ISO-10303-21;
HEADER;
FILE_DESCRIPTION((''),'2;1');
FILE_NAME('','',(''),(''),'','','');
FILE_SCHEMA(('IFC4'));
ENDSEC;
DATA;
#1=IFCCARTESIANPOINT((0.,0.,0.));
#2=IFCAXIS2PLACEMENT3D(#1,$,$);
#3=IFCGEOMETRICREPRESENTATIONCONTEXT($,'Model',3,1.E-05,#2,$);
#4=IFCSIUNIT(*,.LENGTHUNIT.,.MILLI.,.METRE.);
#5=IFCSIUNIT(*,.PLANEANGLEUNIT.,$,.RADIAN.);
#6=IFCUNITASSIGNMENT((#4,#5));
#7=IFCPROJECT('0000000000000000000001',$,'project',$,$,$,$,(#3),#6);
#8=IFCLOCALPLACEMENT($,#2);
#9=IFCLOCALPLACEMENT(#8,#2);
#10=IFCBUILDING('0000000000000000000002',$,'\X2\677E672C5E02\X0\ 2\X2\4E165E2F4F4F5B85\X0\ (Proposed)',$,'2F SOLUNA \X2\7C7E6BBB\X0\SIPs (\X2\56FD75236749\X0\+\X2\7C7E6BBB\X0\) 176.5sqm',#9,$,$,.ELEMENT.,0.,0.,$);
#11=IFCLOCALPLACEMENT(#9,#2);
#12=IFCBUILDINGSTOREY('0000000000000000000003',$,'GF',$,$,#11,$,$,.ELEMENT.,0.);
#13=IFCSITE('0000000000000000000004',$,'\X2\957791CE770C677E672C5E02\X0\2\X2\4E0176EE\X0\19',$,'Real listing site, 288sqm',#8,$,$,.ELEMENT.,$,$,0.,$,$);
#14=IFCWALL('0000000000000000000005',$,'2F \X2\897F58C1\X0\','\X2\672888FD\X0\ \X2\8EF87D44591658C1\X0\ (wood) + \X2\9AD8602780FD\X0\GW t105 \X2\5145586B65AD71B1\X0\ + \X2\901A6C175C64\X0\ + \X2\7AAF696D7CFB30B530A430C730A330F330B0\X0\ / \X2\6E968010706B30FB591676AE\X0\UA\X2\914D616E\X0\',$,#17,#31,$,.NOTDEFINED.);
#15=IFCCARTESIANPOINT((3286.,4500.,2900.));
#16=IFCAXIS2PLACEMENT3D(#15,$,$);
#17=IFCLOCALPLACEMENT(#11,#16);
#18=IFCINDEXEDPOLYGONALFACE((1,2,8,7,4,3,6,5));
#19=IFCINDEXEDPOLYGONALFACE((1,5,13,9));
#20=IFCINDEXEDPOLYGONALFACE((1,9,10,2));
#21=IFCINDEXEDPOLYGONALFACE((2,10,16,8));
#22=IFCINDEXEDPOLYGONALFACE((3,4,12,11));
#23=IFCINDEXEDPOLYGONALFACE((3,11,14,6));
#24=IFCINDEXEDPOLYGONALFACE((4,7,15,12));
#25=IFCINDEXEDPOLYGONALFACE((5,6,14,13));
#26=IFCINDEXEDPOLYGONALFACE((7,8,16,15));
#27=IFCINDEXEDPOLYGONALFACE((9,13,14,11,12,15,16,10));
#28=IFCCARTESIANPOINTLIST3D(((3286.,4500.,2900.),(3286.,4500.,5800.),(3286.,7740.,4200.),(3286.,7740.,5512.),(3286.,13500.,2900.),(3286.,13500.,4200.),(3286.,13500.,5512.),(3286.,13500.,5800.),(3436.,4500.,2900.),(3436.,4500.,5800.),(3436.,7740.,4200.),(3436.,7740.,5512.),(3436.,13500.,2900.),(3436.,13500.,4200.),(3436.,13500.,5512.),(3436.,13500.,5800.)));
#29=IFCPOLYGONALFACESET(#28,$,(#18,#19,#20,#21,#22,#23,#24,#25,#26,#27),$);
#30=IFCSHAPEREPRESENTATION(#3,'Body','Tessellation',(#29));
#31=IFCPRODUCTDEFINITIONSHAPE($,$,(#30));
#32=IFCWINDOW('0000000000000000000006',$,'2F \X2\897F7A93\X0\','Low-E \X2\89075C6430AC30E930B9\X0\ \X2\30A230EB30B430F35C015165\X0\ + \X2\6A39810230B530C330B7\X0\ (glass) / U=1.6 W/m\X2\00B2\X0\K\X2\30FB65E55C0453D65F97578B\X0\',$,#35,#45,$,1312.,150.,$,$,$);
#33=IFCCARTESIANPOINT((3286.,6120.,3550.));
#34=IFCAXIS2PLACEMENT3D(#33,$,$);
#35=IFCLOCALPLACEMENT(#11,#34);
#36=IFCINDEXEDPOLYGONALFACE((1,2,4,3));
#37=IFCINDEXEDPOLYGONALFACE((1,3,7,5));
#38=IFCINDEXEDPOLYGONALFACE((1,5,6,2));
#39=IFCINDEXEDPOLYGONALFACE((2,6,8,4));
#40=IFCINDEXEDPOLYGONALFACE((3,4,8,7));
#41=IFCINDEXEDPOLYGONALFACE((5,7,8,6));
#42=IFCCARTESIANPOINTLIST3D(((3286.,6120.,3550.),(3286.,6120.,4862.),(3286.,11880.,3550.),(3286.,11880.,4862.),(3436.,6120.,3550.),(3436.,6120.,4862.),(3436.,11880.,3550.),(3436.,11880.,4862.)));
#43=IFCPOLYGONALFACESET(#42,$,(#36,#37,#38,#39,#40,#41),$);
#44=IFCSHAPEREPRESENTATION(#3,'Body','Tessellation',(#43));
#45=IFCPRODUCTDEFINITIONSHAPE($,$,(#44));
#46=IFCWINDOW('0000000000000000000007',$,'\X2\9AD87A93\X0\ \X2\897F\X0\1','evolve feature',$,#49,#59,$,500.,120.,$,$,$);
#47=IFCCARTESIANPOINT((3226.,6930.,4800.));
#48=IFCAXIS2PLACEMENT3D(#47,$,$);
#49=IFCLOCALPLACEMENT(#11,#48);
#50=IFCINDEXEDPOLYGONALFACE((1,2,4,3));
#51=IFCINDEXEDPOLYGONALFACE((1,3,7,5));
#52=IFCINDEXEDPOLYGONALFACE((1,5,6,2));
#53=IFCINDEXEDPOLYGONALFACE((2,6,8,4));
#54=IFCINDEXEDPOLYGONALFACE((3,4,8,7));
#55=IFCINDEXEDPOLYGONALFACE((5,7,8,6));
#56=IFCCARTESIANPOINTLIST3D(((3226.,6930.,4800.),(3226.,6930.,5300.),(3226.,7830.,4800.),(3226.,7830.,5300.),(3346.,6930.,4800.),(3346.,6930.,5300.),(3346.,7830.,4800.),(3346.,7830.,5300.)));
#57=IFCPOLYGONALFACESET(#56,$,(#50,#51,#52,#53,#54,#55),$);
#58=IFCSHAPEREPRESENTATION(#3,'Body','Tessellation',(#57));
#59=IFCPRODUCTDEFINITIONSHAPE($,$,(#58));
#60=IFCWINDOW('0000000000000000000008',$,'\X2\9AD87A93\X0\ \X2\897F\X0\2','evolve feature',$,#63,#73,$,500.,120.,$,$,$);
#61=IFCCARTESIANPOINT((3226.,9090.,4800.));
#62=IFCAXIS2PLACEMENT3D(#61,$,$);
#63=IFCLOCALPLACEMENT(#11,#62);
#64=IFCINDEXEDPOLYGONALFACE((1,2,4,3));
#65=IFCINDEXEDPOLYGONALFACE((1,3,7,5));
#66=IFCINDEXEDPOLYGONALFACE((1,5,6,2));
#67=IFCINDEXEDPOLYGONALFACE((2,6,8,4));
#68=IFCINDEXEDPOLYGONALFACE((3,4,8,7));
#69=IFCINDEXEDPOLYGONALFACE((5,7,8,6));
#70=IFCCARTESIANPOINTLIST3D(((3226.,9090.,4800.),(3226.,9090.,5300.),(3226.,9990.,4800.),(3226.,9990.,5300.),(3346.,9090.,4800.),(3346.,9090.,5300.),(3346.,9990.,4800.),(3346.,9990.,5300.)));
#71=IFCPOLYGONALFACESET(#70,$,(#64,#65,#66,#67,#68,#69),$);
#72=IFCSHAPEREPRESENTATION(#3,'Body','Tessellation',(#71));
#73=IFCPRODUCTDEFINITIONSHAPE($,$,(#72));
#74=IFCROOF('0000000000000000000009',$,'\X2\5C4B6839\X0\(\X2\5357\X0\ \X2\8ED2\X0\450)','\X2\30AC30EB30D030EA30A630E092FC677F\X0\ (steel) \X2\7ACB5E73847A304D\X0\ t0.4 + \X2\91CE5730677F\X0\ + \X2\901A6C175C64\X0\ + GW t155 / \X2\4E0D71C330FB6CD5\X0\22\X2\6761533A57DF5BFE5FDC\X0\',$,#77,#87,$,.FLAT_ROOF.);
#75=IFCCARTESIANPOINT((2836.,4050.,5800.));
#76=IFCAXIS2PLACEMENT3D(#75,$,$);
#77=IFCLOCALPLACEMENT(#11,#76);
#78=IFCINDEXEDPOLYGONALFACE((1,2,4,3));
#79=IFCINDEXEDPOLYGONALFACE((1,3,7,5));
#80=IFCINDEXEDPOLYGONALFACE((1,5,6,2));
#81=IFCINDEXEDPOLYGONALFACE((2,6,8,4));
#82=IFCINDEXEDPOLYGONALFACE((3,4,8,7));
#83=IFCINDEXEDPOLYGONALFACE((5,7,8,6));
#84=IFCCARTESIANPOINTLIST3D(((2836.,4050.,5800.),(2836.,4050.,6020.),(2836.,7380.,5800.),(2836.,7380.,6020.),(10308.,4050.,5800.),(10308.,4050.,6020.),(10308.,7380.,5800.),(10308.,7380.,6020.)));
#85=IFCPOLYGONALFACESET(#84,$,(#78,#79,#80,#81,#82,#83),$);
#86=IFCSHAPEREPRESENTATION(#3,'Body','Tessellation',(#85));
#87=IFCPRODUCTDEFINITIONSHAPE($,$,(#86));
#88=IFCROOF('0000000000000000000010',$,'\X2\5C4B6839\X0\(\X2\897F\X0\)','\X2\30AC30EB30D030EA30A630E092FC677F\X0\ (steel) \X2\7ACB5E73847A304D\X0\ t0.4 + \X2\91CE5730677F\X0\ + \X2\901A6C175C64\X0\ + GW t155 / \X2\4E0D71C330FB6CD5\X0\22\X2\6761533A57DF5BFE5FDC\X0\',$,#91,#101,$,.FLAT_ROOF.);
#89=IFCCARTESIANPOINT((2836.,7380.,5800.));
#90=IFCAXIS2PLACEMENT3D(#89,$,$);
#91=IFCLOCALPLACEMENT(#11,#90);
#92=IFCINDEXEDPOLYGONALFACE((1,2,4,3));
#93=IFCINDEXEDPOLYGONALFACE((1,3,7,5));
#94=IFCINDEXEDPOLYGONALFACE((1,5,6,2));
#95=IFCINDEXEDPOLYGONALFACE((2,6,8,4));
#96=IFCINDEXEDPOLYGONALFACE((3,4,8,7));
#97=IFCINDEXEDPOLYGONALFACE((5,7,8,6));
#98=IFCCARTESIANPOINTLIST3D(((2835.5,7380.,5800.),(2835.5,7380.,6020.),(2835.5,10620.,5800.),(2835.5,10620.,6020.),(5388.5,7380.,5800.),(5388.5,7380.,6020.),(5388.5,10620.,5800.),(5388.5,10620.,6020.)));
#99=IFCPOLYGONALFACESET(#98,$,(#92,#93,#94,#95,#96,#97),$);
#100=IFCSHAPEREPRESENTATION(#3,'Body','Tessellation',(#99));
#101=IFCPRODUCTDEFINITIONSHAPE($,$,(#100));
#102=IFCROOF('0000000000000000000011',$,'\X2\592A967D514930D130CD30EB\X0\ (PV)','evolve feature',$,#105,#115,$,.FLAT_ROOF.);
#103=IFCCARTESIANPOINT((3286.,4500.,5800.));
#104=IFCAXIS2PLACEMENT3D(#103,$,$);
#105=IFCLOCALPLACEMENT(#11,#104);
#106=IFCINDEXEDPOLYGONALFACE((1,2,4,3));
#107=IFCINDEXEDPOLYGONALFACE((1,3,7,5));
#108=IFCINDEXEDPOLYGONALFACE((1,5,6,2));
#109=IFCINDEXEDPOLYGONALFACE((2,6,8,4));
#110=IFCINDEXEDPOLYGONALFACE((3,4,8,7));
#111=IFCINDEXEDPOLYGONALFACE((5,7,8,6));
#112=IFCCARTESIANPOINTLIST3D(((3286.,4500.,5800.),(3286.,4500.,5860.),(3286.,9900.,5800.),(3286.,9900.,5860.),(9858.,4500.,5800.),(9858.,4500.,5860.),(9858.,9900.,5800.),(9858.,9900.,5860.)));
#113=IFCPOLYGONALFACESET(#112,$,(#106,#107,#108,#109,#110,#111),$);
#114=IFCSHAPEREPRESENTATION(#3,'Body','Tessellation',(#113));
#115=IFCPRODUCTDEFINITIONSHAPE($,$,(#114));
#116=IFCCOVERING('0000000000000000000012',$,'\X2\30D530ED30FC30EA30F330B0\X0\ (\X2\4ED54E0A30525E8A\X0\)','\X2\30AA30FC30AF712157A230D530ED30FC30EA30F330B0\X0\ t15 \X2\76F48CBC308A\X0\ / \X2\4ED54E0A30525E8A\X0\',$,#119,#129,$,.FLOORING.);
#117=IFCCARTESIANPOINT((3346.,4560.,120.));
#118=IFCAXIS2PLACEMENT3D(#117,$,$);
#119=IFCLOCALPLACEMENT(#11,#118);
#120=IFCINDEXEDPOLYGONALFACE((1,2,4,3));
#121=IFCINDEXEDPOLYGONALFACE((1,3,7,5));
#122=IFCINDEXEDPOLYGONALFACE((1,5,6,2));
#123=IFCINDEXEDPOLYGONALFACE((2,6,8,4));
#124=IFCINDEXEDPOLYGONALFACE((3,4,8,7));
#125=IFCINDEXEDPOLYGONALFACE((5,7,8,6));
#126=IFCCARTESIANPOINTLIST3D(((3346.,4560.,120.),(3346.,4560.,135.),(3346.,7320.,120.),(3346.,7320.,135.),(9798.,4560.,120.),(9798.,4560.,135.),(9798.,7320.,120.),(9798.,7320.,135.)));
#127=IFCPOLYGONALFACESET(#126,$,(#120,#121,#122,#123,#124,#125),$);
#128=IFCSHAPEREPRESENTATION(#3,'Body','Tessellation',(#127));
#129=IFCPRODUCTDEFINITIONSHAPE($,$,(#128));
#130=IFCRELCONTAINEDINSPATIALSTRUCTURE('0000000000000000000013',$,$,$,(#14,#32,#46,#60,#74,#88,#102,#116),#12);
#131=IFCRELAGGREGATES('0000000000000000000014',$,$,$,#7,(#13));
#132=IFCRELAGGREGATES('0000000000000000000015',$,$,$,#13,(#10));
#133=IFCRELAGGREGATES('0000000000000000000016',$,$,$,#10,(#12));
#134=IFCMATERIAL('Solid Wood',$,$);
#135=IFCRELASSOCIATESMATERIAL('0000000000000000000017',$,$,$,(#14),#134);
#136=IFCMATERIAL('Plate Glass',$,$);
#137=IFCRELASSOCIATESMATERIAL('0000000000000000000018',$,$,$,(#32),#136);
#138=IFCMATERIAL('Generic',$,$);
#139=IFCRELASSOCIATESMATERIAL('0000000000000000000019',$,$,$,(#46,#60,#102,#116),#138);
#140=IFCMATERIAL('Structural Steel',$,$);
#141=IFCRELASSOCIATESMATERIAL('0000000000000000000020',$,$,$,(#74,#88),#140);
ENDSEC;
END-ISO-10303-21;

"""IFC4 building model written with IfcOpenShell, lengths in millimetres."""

from ifc_helpers import new_model, si_unit, frame, frame_2d, origin, place, context, project, spatial, rectangle, extrude, material, element, fill, save


model = new_model("IFC4")

# Units and contexts
model_context = context("Model", 3, precision=1e-05, world=origin())
ifc_project = project(units=[si_unit("LENGTHUNIT", "METRE", prefix="MILLI"), si_unit("PLANEANGLEUNIT", "RADIAN")], contexts=[model_context])

# Site, building, storey
site_placement = place(None, origin())
site = spatial("IfcSite", under=ifc_project, at=site_placement, Name="長野県松本市2丁目19", ObjectType="Real listing site, 288sqm", CompositionType="ELEMENT", RefElevation=0.0)
building_placement = place(site_placement, origin())
building = spatial("IfcBuilding", under=site, at=building_placement, Name="松本市 2世帯住宅 (Proposed)", ObjectType="2F SOLUNA 籾殻SIPs (国産杉+籾殻) 176.5sqm", CompositionType="ELEMENT", ElevationOfRefHeight=0.0, ElevationOfTerrain=0.0)
storey_placement = place(building_placement, origin())
storey = spatial("IfcBuildingStorey", under=building, at=storey_placement, Name="GF", CompositionType="ELEMENT", Elevation=0.0)

# Shared definitions
ifc_material_1 = material(Name="Solid Wood")
ifc_material_2 = material(Name="Generic")

# Shared definitions
ifc_material_3 = material(Name="Plate Glass")

# Wall, openings, windows
wall_1_placement = place(storey_placement, frame((3286.0, 4500.0, 2900.0)))
wall_1 = element("IfcWall", 1, at=wall_1_placement, inside=storey, material=ifc_material_1, Name="2F 西壁", Description="木製 軸組外壁 (wood) + 高性能GW t105 充填断熱 + 通気層 + 窯業系サイディング / 準耐火・外皮UA配慮", PredefinedType="NOTDEFINED", context=model_context, shape_type="SweptSolid", body=[
    extrude(rectangle(XDim=150.0, YDim=9000.0, at=frame_2d((75.0, 4500.0))), frame((3286.0, 4500.0, 2900.0)), (0.0, 0.0, 1.0), 2900.0),
])
opening_1_placement = place(storey_placement, frame((3286.0, 6120.0, 3550.0)))
opening_1 = element("IfcOpeningElement", 2, at=opening_1_placement, cuts=wall_1, PredefinedType="NOTDEFINED", context=model_context, shape_type="SweptSolid", body=[
    extrude(rectangle(XDim=150.0, YDim=5760.0, at=frame_2d((75.0, 2880.0))), frame((3286.0, 6120.0, 3550.0)), (0.0, 0.0, 1.0), 1312.0),
])
opening_2_placement = place(storey_placement, frame((3226.0, 6930.0, 4800.0)))
opening_2 = element("IfcOpeningElement", 3, at=opening_2_placement, cuts=wall_1, PredefinedType="NOTDEFINED", context=model_context, shape_type="SweptSolid", body=[
    extrude(rectangle(XDim=120.0, YDim=900.0, at=frame_2d((60.0, 450.0))), frame((3226.0, 6930.0, 4800.0)), (0.0, 0.0, 1.0), 500.0),
])
opening_3_placement = place(storey_placement, frame((3226.0, 9090.0, 4800.0)))
opening_3 = element("IfcOpeningElement", 4, at=opening_3_placement, cuts=wall_1, PredefinedType="NOTDEFINED", context=model_context, shape_type="SweptSolid", body=[
    extrude(rectangle(XDim=120.0, YDim=900.0, at=frame_2d((60.0, 450.0))), frame((3226.0, 9090.0, 4800.0)), (0.0, 0.0, 1.0), 500.0),
])
window_1_placement = place(storey_placement, frame((3286.0, 6120.0, 3550.0)))
window_1 = element("IfcWindow", 5, at=window_1_placement, inside=storey, material=ifc_material_3, Name="2F 西窓", Description="Low-E 複層ガラス アルゴン封入 + 樹脂サッシ (glass) / U=1.6 W/m²K・日射取得型", OverallHeight=1312.0, OverallWidth=150.0, context=model_context, shape_type="SweptSolid", body=[
    extrude(rectangle(XDim=150.0, YDim=5760.0, at=frame_2d((75.0, 2880.0))), frame((3286.0, 6120.0, 3550.0)), (0.0, 0.0, 1.0), 1312.0),
])
fill(opening_1, window_1)
window_2_placement = place(storey_placement, frame((3226.0, 6930.0, 4800.0)))
window_2 = element("IfcWindow", 6, at=window_2_placement, inside=storey, material=ifc_material_2, Name="高窓 西1", Description="evolve feature", OverallHeight=500.0, OverallWidth=120.0, context=model_context, shape_type="SweptSolid", body=[
    extrude(rectangle(XDim=120.0, YDim=900.0, at=frame_2d((60.0, 450.0))), frame((3226.0, 6930.0, 4800.0)), (0.0, 0.0, 1.0), 500.0),
])
fill(opening_2, window_2)
window_3_placement = place(storey_placement, frame((3226.0, 9090.0, 4800.0)))
window_3 = element("IfcWindow", 7, at=window_3_placement, inside=storey, material=ifc_material_2, Name="高窓 西2", Description="evolve feature", OverallHeight=500.0, OverallWidth=120.0, context=model_context, shape_type="SweptSolid", body=[
    extrude(rectangle(XDim=120.0, YDim=900.0, at=frame_2d((60.0, 450.0))), frame((3226.0, 9090.0, 4800.0)), (0.0, 0.0, 1.0), 500.0),
])
fill(opening_3, window_3)

# Roofs
ifc_material_4 = material(Name="Structural Steel")
roof_1_placement = place(storey_placement, frame((2836.0, 4050.0, 5800.0)))
element("IfcRoof", 8, at=roof_1_placement, inside=storey, material=ifc_material_4, Name="屋根(南 軒450)", Description="ガルバリウム鋼板 (steel) 立平葺き t0.4 + 野地板 + 通気層 + GW t155 / 不燃・法22条区域対応", PredefinedType="FLAT_ROOF", context=model_context, shape_type="SweptSolid", body=[
    extrude(rectangle(XDim=7472.0, YDim=3330.0, at=frame_2d((3736.0, 1665.0))), frame((2836.0, 4050.0, 5800.0)), (0.0, 0.0, 1.0), 220.0),
])
roof_2_placement = place(storey_placement, frame((2836.0, 7380.0, 5800.0)))
element("IfcRoof", 9, at=roof_2_placement, inside=storey, material=ifc_material_4, Name="屋根(西)", Description="ガルバリウム鋼板 (steel) 立平葺き t0.4 + 野地板 + 通気層 + GW t155 / 不燃・法22条区域対応", PredefinedType="FLAT_ROOF", context=model_context, shape_type="SweptSolid", body=[
    extrude(rectangle(XDim=2553.0, YDim=3240.0, at=frame_2d((1276.0, 1620.0))), frame((2836.0, 7380.0, 5800.0)), (0.0, 0.0, 1.0), 220.0),
])
roof_3_placement = place(storey_placement, frame((3286.0, 4500.0, 5800.0)))
element("IfcRoof", 10, at=roof_3_placement, inside=storey, material=ifc_material_2, Name="太陽光パネル (PV)", Description="evolve feature", PredefinedType="FLAT_ROOF", context=model_context, shape_type="SweptSolid", body=[
    extrude(rectangle(XDim=6572.0, YDim=5400.0, at=frame_2d((3286.0, 2700.0))), frame((3286.0, 4500.0, 5800.0)), (0.0, 0.0, 1.0), 60.0),
])

# Covering
covering_placement = place(storey_placement, frame((3346.0, 4560.0, 120.0)))
element("IfcCovering", 11, at=covering_placement, inside=storey, material=ifc_material_2, Name="フローリング (仕上げ床)", Description="オーク無垢フローリング t15 直貼り / 仕上げ床", PredefinedType="FLOORING", context=model_context, shape_type="SweptSolid", body=[
    extrude(rectangle(XDim=6452.0, YDim=2760.0, at=frame_2d((3226.0, 1380.0))), frame((3346.0, 4560.0, 120.0)), (0.0, 0.0, 1.0), 15.0),
])

save(model, "model.ifc")
